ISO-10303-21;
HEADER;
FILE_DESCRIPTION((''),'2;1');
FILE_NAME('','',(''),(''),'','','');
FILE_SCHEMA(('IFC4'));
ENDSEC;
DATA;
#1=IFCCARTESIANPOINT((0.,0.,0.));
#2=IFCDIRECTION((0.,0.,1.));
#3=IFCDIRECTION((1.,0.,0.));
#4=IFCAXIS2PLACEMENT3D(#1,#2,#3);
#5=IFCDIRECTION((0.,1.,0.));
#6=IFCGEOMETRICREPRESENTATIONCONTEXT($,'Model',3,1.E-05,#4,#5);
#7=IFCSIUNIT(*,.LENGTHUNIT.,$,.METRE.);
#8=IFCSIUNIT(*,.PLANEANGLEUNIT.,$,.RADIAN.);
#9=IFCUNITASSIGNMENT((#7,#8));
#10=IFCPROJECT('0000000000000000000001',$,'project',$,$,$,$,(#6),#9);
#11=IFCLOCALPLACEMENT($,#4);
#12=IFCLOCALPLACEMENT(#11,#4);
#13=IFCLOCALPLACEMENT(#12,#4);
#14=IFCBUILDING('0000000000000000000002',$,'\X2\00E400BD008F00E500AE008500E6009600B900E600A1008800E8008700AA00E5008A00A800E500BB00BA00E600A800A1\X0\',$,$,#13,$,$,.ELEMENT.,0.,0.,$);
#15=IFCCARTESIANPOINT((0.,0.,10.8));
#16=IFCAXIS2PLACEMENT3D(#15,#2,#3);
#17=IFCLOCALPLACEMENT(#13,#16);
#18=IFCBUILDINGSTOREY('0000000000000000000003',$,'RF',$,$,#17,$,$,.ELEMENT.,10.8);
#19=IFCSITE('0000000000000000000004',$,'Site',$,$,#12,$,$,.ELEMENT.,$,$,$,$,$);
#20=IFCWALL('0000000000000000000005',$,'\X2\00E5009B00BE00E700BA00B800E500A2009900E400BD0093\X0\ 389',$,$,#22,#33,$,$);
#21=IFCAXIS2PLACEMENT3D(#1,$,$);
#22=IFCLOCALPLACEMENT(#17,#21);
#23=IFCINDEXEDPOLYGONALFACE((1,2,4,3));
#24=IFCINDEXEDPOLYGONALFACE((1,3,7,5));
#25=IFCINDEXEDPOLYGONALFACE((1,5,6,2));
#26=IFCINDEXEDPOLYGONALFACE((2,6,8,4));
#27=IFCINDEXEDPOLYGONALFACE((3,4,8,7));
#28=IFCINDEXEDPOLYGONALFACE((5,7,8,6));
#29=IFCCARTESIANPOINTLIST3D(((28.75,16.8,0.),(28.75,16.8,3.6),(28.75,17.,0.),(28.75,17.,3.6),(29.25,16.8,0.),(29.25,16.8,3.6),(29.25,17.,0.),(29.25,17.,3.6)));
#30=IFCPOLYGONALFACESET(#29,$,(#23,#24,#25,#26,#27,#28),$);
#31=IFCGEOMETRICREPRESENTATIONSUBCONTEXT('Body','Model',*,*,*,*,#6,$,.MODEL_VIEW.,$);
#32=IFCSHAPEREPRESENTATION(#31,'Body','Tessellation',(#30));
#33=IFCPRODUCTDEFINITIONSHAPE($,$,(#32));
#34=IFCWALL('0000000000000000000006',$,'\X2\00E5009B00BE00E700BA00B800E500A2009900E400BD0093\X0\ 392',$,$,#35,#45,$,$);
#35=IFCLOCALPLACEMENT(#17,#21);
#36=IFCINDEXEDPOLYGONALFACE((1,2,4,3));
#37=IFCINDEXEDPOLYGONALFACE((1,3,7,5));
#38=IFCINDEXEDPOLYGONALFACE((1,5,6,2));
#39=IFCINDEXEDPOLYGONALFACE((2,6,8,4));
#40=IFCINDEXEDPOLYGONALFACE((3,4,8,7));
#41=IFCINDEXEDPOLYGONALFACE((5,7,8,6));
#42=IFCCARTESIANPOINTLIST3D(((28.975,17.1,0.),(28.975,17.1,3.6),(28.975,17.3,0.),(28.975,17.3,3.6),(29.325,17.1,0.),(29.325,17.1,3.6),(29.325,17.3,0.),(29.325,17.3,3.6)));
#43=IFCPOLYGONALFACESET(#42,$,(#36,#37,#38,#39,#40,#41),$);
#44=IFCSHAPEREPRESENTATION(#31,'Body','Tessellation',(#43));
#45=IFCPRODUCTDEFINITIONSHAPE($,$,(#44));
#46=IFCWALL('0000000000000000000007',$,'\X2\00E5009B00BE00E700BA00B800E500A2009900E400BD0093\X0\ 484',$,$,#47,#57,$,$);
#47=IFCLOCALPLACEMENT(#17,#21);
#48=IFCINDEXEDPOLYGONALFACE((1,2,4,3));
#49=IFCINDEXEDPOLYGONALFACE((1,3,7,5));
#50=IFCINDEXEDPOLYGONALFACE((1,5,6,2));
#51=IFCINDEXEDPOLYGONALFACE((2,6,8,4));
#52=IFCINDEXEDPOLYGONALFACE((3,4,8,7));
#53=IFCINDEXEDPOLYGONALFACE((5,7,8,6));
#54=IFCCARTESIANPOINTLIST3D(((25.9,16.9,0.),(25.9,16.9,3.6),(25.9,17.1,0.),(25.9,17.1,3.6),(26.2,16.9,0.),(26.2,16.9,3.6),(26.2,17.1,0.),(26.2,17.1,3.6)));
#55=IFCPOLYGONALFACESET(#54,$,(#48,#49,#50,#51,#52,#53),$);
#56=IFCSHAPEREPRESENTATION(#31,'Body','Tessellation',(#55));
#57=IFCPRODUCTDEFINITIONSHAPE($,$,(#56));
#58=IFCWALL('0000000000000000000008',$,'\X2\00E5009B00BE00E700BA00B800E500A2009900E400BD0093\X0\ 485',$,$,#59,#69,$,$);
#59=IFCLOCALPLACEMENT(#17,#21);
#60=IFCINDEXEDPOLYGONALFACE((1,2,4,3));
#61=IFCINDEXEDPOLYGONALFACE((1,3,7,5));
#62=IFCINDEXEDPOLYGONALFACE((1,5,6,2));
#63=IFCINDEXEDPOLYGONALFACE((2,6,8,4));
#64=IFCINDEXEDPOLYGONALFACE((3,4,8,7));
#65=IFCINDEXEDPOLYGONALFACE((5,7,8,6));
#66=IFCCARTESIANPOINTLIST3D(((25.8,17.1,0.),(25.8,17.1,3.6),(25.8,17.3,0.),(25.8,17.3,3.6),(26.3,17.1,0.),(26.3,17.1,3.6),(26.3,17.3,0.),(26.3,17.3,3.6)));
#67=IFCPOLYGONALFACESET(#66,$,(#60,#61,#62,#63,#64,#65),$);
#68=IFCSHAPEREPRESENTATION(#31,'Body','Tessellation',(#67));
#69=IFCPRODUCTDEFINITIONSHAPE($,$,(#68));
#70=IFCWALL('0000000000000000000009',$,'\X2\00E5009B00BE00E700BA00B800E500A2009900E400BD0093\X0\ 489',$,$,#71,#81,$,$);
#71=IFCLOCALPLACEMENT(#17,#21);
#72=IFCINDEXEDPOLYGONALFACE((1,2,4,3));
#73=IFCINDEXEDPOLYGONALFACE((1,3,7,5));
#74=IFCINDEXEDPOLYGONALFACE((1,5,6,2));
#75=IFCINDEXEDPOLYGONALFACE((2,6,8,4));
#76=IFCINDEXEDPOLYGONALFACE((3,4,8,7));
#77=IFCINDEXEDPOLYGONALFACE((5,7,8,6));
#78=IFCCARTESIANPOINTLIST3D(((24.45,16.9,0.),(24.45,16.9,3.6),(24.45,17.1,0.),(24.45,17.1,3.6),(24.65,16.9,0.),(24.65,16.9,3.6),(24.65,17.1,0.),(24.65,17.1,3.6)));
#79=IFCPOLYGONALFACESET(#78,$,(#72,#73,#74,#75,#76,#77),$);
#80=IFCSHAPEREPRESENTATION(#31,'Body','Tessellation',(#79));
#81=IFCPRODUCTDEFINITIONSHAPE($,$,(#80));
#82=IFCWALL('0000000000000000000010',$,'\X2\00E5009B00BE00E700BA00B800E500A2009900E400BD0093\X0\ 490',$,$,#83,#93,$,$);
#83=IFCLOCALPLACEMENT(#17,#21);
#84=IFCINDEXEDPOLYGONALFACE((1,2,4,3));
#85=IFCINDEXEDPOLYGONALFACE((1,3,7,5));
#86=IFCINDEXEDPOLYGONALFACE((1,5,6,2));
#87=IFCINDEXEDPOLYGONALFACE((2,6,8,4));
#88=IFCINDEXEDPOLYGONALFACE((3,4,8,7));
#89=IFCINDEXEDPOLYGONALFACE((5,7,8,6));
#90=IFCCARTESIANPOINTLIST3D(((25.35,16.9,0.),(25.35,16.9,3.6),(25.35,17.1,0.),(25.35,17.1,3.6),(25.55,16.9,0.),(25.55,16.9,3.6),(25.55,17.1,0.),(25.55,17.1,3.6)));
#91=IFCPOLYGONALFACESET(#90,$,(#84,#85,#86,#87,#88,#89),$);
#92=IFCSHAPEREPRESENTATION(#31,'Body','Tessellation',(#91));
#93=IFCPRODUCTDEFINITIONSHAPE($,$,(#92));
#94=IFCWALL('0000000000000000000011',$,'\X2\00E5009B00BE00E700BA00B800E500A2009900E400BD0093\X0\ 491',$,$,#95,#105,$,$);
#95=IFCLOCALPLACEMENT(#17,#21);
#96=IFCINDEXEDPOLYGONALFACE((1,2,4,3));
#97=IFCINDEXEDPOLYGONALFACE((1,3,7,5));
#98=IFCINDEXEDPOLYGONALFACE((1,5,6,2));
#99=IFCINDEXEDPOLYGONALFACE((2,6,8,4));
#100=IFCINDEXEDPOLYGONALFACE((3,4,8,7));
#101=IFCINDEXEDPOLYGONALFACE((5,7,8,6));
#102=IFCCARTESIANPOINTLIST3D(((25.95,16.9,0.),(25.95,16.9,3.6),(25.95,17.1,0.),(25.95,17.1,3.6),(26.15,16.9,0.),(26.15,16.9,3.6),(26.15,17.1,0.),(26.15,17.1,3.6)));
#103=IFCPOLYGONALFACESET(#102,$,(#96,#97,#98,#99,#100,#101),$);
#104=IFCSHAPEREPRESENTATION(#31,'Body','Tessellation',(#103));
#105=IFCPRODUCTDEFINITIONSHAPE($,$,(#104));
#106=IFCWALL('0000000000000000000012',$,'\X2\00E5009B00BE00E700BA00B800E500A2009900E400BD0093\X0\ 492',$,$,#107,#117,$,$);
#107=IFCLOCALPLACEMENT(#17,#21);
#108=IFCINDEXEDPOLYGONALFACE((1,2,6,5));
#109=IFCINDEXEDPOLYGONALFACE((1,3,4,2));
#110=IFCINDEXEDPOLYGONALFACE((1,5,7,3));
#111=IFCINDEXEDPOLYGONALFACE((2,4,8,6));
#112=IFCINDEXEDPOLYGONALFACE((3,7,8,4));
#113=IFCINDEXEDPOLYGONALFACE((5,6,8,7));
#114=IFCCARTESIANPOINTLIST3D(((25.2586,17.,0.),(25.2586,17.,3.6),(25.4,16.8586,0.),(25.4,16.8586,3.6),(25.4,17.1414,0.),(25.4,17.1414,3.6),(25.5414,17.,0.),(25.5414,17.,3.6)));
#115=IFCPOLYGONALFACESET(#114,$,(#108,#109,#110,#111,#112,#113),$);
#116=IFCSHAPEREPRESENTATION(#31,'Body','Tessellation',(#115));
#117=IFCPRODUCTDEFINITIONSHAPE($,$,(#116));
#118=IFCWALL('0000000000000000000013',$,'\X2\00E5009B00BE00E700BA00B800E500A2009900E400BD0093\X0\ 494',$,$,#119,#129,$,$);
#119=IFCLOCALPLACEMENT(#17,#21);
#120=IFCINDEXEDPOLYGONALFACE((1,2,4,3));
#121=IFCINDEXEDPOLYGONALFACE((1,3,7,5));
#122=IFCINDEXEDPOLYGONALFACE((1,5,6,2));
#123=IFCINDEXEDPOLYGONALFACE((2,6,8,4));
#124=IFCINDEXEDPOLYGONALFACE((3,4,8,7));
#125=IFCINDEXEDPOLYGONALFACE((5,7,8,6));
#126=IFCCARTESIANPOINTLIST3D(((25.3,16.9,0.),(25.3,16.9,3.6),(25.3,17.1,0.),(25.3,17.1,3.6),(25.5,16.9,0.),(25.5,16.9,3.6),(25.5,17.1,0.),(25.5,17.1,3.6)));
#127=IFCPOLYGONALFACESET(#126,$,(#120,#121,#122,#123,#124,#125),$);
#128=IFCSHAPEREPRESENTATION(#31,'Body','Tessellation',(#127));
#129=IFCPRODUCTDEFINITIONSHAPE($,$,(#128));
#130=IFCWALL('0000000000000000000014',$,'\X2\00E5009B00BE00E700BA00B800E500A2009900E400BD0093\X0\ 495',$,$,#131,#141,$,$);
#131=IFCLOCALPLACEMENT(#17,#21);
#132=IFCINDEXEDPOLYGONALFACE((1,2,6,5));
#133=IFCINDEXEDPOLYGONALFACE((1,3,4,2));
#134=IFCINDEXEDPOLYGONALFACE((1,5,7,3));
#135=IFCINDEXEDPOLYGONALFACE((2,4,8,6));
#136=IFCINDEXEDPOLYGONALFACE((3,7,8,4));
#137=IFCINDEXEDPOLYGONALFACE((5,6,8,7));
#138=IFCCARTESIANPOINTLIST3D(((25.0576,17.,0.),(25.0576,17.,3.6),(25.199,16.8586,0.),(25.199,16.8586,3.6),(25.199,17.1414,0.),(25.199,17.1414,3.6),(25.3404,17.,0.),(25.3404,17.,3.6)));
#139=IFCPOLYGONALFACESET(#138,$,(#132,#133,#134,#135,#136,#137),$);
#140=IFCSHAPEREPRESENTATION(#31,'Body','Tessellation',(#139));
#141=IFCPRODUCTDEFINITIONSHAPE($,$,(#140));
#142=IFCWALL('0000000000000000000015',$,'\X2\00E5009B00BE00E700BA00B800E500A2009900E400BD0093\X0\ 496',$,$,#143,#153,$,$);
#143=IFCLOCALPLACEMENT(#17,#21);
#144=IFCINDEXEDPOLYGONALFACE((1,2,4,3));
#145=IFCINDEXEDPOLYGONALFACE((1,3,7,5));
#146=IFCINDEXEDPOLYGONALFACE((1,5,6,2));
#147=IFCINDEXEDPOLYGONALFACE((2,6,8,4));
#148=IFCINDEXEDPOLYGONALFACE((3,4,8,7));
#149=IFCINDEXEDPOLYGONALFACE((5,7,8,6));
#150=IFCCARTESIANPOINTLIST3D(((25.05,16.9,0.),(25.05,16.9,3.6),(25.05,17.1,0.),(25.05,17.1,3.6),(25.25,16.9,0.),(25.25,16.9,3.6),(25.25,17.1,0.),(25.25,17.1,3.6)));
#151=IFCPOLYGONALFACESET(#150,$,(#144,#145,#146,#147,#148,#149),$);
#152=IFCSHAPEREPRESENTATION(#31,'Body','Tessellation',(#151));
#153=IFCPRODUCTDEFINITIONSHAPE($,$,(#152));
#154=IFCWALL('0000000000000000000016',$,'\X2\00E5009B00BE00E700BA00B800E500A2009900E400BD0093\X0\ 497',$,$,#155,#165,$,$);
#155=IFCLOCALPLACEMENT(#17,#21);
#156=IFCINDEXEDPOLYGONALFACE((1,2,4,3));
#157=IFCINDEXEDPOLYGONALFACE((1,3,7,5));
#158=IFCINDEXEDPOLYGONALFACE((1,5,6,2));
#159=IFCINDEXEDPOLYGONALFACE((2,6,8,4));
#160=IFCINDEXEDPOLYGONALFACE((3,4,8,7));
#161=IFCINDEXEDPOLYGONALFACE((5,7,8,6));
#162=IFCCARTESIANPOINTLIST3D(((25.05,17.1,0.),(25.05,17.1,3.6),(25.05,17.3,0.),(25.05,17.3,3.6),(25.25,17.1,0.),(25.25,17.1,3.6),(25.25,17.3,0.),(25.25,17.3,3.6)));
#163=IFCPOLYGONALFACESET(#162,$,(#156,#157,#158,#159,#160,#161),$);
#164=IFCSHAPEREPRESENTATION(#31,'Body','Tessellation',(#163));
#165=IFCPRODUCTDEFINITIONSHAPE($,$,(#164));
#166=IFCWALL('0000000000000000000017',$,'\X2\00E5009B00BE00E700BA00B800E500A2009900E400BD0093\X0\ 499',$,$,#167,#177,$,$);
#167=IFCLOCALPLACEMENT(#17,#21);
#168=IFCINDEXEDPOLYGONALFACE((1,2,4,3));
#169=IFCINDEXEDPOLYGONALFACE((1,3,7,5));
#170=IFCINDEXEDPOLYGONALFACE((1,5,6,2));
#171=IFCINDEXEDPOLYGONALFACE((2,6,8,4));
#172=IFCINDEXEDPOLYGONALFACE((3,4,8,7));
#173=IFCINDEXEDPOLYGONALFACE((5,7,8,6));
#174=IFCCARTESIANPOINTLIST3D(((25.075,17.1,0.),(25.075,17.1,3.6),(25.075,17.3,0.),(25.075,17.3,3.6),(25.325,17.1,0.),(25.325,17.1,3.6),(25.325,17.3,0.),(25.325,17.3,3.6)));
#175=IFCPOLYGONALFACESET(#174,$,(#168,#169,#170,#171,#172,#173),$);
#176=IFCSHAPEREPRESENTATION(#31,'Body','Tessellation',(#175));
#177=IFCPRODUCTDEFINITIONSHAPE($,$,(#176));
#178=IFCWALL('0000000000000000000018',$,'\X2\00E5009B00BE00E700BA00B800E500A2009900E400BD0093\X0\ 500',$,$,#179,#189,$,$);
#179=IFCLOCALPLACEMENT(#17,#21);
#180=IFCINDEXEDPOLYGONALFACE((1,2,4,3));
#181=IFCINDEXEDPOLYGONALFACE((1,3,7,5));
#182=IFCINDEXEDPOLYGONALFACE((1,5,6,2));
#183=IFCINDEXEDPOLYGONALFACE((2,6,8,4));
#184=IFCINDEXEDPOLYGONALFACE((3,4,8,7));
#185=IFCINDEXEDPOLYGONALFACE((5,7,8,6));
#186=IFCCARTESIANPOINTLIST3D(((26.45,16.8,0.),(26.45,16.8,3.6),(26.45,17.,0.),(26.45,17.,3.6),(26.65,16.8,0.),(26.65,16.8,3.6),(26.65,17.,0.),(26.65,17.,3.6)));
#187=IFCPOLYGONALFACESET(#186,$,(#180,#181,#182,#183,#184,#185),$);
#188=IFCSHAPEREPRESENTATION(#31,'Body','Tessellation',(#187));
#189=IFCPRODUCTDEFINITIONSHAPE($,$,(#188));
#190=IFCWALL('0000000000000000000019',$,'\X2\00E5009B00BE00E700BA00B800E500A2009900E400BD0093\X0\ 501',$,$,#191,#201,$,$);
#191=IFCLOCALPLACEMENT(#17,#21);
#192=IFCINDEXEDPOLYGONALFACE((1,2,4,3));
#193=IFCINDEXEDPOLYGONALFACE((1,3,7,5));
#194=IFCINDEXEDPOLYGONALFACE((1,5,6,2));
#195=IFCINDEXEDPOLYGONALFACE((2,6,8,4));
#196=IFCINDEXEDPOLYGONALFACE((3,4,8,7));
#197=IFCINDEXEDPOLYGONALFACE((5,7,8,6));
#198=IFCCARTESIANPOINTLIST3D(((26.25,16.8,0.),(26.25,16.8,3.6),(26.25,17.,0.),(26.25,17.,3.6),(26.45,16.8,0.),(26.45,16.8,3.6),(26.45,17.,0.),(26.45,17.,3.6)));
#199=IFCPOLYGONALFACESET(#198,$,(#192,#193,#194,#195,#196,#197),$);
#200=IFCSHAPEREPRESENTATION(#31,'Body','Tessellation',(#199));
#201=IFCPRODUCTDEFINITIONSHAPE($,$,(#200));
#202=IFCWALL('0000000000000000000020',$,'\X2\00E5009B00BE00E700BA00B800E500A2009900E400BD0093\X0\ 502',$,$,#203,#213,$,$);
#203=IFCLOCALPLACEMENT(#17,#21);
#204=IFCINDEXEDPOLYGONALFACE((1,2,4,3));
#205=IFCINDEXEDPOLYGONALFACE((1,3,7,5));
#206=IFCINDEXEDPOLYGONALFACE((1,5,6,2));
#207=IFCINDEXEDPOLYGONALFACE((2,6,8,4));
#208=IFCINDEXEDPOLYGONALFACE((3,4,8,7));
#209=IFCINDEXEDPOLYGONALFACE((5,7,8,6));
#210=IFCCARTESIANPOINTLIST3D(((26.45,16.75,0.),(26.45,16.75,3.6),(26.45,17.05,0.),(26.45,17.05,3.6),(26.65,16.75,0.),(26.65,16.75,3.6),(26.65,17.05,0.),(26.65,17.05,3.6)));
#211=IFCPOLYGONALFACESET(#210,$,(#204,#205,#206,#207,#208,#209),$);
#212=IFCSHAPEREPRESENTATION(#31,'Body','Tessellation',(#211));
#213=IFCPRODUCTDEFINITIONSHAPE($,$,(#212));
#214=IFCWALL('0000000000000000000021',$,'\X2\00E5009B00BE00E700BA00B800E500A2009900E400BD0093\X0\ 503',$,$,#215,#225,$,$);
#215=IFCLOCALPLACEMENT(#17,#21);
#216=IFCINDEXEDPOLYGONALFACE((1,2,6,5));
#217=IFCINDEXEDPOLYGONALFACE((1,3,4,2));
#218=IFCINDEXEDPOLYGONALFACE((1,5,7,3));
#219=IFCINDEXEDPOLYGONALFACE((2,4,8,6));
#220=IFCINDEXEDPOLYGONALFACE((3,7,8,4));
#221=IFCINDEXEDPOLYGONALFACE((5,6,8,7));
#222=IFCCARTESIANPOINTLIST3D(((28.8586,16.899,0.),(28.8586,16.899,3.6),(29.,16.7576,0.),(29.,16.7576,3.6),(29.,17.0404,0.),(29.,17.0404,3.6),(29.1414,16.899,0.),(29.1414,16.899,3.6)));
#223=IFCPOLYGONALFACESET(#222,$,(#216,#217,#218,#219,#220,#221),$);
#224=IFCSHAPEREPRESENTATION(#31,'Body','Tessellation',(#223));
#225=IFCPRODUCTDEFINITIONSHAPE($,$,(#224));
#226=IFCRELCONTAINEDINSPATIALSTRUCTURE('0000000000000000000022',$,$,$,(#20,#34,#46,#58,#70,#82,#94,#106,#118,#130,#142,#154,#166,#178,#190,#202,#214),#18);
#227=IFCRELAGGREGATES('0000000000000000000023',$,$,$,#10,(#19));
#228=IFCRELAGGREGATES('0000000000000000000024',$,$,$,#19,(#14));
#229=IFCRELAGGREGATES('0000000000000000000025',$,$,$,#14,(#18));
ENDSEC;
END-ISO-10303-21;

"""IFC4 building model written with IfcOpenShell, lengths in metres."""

from ifc_helpers import new_model, si_unit, direction, frame, frame_2d, origin_with_axes, place, context, subcontext, project, spatial, rectangle, extrude, element, save


model = new_model("IFC4")

# Units and contexts
model_context = context("Model", 3, precision=1e-05, world=origin_with_axes(), true_north=direction((0.0, 1.0, 0.0)))
body_context = subcontext(model_context, "Body", "Model", "MODEL_VIEW")
ifc_project = project(units=[si_unit("LENGTHUNIT", "METRE"), si_unit("PLANEANGLEUNIT", "RADIAN")], contexts=[model_context])

# Site, building, storey
placement = place(None, origin_with_axes())
site_placement = place(placement, origin_with_axes())
site = spatial("IfcSite", under=ifc_project, at=site_placement, Name="Site", CompositionType="ELEMENT")
building_placement = place(site_placement, origin_with_axes())
building = spatial("IfcBuilding", under=site, at=building_placement, Name="ä½\u008få®\u0085æ\u0096¹æ¡\u0088è\u0087ªå\u008a¨å»ºæ¨¡", CompositionType="ELEMENT", ElevationOfRefHeight=0.0, ElevationOfTerrain=0.0)
storey_placement = place(building_placement, frame((0.0, 0.0, 10.8), z_axis=(0.0, 0.0, 1.0), x_axis=(1.0, 0.0, 0.0)))
storey = spatial("IfcBuildingStorey", under=building, at=storey_placement, Name="RF", CompositionType="ELEMENT", Elevation=10.8)

# Walls
wall_1_placement = place(storey_placement, frame((29.0, 16.9, 0.0), z_axis=(0.0, 0.0, 1.0), x_axis=(1.0, 0.0, 0.0)))
element("IfcWall", 1, at=wall_1_placement, inside=storey, Name="å\u009b¾çº¸å¢\u0099ä½\u0093 389", context=body_context, shape_type="SweptSolid", body=[
    extrude(rectangle(XDim=0.5, YDim=0.2, at=frame_2d((0.0, 0.0), x_axis=(1.0, 0.0, 0.0))), frame((0.0, 0.0, 0.0), z_axis=(0.0, 0.0, 1.0)), (0.0, 0.0, 1.0), 3.6),
])
wall_2_placement = place(storey_placement, frame((29.15, 17.2, 0.0), z_axis=(0.0, 0.0, 1.0), x_axis=(1.0, 0.0, 0.0)))
element("IfcWall", 2, at=wall_2_placement, inside=storey, Name="å\u009b¾çº¸å¢\u0099ä½\u0093 392", context=body_context, shape_type="SweptSolid", body=[
    extrude(rectangle(XDim=0.35, YDim=0.2, at=frame_2d((0.0, 0.0), x_axis=(1.0, 0.0, 0.0))), frame((0.0, 0.0, 0.0), z_axis=(0.0, 0.0, 1.0)), (0.0, 0.0, 1.0), 3.6),
])
wall_3_placement = place(storey_placement, frame((26.05, 17.0, 0.0), z_axis=(0.0, 0.0, 1.0), x_axis=(1.0, 0.0, 0.0)))
element("IfcWall", 3, at=wall_3_placement, inside=storey, Name="å\u009b¾çº¸å¢\u0099ä½\u0093 484", context=body_context, shape_type="SweptSolid", body=[
    extrude(rectangle(XDim=0.3, YDim=0.2, at=frame_2d((0.0, 0.0), x_axis=(1.0, 0.0, 0.0))), frame((0.0, 0.0, 0.0), z_axis=(0.0, 0.0, 1.0)), (0.0, 0.0, 1.0), 3.6),
])
wall_4_placement = place(storey_placement, frame((26.05, 17.2, 0.0), z_axis=(0.0, 0.0, 1.0), x_axis=(1.0, 0.0, 0.0)))
element("IfcWall", 4, at=wall_4_placement, inside=storey, Name="å\u009b¾çº¸å¢\u0099ä½\u0093 485", context=body_context, shape_type="SweptSolid", body=[
    extrude(rectangle(XDim=0.5, YDim=0.2, at=frame_2d((0.0, 0.0), x_axis=(1.0, 0.0, 0.0))), frame((0.0, 0.0, 0.0), z_axis=(0.0, 0.0, 1.0)), (0.0, 0.0, 1.0), 3.6),
])
for number, where, z_axis, x_axis, name in (
    (5, (24.55, 17.0, 0.0), (0.0, 0.0, 1.0), (0.0, 1.0, 0.0), "å\u009b¾çº¸å¢\u0099ä½\u0093 489"),
    (6, (25.45, 17.0, 0.0), (0.0, 0.0, 1.0), (0.0, 1.0, 0.0), "å\u009b¾çº¸å¢\u0099ä½\u0093 490"),
    (7, (26.05, 17.0, 0.0), (0.0, 0.0, 1.0), (0.0, 1.0, 0.0), "å\u009b¾çº¸å¢\u0099ä½\u0093 491"),
    (8, (25.4, 17.0, 0.0), (0.0, 0.0, 1.0), (-0.707107, -0.707107, 0.0), "å\u009b¾çº¸å¢\u0099ä½\u0093 492"),
    (9, (25.4, 17.0, 0.0), (0.0, 0.0, 1.0), (1.0, 0.0, 0.0), "å\u009b¾çº¸å¢\u0099ä½\u0093 494"),
    (10, (25.199, 17.0, 0.0), (0.0, 0.0, 1.0), (0.707107, -0.707107, 0.0), "å\u009b¾çº¸å¢\u0099ä½\u0093 495"),
    (11, (25.15, 17.0, 0.0), (0.0, 0.0, 1.0), (1.0, 0.0, 0.0), "å\u009b¾çº¸å¢\u0099ä½\u0093 496"),
    (12, (25.15, 17.2, 0.0), (0.0, 0.0, 1.0), (1.0, 0.0, 0.0), "å\u009b¾çº¸å¢\u0099ä½\u0093 497"),
):
    element("IfcWall", number, at=place(storey_placement, frame(where, z_axis=z_axis, x_axis=x_axis)), inside=storey, Name=name, context=body_context, shape_type="SweptSolid", body=[
        extrude(rectangle(XDim=0.2, YDim=0.2, at=frame_2d((0.0, 0.0), x_axis=(1.0, 0.0, 0.0))), frame((0.0, 0.0, 0.0), z_axis=(0.0, 0.0, 1.0)), (0.0, 0.0, 1.0), 3.6),
    ])
wall_5_placement = place(storey_placement, frame((25.2, 17.2, 0.0), z_axis=(0.0, 0.0, 1.0), x_axis=(1.0, 0.0, 0.0)))
element("IfcWall", 13, at=wall_5_placement, inside=storey, Name="å\u009b¾çº¸å¢\u0099ä½\u0093 499", context=body_context, shape_type="SweptSolid", body=[
    extrude(rectangle(XDim=0.25, YDim=0.2, at=frame_2d((0.0, 0.0), x_axis=(1.0, 0.0, 0.0))), frame((0.0, 0.0, 0.0), z_axis=(0.0, 0.0, 1.0)), (0.0, 0.0, 1.0), 3.6),
])
for number, where, z_axis, x_axis, name in (
    (14, (26.55, 16.9, 0.0), (0.0, 0.0, 1.0), (-1.0, 0.0, 0.0), "å\u009b¾çº¸å¢\u0099ä½\u0093 500"),
    (15, (26.35, 16.9, 0.0), (0.0, 0.0, 1.0), (0.0, 1.0, 0.0), "å\u009b¾çº¸å¢\u0099ä½\u0093 501"),
):
    element("IfcWall", number, at=place(storey_placement, frame(where, z_axis=z_axis, x_axis=x_axis)), inside=storey, Name=name, context=body_context, shape_type="SweptSolid", body=[
        extrude(rectangle(XDim=0.2, YDim=0.2, at=frame_2d((0.0, 0.0), x_axis=(1.0, 0.0, 0.0))), frame((0.0, 0.0, 0.0), z_axis=(0.0, 0.0, 1.0)), (0.0, 0.0, 1.0), 3.6),
    ])
wall_6_placement = place(storey_placement, frame((26.55, 16.9, 0.0), z_axis=(0.0, 0.0, 1.0), x_axis=(0.0, 1.0, 0.0)))
element("IfcWall", 16, at=wall_6_placement, inside=storey, Name="å\u009b¾çº¸å¢\u0099ä½\u0093 502", context=body_context, shape_type="SweptSolid", body=[
    extrude(rectangle(XDim=0.3, YDim=0.2, at=frame_2d((0.0, 0.0), x_axis=(1.0, 0.0, 0.0))), frame((0.0, 0.0, 0.0), z_axis=(0.0, 0.0, 1.0)), (0.0, 0.0, 1.0), 3.6),
])
for number, where, z_axis, x_axis, name in (
    (17, (29.0, 16.899, 0.0), (0.0, 0.0, 1.0), (0.707107, 0.707107, 0.0), "å\u009b¾çº¸å¢\u0099ä½\u0093 503"),
):
    element("IfcWall", number, at=place(storey_placement, frame(where, z_axis=z_axis, x_axis=x_axis)), inside=storey, Name=name, context=body_context, shape_type="SweptSolid", body=[
        extrude(rectangle(XDim=0.2, YDim=0.2, at=frame_2d((0.0, 0.0), x_axis=(1.0, 0.0, 0.0))), frame((0.0, 0.0, 0.0), z_axis=(0.0, 0.0, 1.0)), (0.0, 0.0, 1.0), 3.6),
    ])

save(model, "model.ifc")
